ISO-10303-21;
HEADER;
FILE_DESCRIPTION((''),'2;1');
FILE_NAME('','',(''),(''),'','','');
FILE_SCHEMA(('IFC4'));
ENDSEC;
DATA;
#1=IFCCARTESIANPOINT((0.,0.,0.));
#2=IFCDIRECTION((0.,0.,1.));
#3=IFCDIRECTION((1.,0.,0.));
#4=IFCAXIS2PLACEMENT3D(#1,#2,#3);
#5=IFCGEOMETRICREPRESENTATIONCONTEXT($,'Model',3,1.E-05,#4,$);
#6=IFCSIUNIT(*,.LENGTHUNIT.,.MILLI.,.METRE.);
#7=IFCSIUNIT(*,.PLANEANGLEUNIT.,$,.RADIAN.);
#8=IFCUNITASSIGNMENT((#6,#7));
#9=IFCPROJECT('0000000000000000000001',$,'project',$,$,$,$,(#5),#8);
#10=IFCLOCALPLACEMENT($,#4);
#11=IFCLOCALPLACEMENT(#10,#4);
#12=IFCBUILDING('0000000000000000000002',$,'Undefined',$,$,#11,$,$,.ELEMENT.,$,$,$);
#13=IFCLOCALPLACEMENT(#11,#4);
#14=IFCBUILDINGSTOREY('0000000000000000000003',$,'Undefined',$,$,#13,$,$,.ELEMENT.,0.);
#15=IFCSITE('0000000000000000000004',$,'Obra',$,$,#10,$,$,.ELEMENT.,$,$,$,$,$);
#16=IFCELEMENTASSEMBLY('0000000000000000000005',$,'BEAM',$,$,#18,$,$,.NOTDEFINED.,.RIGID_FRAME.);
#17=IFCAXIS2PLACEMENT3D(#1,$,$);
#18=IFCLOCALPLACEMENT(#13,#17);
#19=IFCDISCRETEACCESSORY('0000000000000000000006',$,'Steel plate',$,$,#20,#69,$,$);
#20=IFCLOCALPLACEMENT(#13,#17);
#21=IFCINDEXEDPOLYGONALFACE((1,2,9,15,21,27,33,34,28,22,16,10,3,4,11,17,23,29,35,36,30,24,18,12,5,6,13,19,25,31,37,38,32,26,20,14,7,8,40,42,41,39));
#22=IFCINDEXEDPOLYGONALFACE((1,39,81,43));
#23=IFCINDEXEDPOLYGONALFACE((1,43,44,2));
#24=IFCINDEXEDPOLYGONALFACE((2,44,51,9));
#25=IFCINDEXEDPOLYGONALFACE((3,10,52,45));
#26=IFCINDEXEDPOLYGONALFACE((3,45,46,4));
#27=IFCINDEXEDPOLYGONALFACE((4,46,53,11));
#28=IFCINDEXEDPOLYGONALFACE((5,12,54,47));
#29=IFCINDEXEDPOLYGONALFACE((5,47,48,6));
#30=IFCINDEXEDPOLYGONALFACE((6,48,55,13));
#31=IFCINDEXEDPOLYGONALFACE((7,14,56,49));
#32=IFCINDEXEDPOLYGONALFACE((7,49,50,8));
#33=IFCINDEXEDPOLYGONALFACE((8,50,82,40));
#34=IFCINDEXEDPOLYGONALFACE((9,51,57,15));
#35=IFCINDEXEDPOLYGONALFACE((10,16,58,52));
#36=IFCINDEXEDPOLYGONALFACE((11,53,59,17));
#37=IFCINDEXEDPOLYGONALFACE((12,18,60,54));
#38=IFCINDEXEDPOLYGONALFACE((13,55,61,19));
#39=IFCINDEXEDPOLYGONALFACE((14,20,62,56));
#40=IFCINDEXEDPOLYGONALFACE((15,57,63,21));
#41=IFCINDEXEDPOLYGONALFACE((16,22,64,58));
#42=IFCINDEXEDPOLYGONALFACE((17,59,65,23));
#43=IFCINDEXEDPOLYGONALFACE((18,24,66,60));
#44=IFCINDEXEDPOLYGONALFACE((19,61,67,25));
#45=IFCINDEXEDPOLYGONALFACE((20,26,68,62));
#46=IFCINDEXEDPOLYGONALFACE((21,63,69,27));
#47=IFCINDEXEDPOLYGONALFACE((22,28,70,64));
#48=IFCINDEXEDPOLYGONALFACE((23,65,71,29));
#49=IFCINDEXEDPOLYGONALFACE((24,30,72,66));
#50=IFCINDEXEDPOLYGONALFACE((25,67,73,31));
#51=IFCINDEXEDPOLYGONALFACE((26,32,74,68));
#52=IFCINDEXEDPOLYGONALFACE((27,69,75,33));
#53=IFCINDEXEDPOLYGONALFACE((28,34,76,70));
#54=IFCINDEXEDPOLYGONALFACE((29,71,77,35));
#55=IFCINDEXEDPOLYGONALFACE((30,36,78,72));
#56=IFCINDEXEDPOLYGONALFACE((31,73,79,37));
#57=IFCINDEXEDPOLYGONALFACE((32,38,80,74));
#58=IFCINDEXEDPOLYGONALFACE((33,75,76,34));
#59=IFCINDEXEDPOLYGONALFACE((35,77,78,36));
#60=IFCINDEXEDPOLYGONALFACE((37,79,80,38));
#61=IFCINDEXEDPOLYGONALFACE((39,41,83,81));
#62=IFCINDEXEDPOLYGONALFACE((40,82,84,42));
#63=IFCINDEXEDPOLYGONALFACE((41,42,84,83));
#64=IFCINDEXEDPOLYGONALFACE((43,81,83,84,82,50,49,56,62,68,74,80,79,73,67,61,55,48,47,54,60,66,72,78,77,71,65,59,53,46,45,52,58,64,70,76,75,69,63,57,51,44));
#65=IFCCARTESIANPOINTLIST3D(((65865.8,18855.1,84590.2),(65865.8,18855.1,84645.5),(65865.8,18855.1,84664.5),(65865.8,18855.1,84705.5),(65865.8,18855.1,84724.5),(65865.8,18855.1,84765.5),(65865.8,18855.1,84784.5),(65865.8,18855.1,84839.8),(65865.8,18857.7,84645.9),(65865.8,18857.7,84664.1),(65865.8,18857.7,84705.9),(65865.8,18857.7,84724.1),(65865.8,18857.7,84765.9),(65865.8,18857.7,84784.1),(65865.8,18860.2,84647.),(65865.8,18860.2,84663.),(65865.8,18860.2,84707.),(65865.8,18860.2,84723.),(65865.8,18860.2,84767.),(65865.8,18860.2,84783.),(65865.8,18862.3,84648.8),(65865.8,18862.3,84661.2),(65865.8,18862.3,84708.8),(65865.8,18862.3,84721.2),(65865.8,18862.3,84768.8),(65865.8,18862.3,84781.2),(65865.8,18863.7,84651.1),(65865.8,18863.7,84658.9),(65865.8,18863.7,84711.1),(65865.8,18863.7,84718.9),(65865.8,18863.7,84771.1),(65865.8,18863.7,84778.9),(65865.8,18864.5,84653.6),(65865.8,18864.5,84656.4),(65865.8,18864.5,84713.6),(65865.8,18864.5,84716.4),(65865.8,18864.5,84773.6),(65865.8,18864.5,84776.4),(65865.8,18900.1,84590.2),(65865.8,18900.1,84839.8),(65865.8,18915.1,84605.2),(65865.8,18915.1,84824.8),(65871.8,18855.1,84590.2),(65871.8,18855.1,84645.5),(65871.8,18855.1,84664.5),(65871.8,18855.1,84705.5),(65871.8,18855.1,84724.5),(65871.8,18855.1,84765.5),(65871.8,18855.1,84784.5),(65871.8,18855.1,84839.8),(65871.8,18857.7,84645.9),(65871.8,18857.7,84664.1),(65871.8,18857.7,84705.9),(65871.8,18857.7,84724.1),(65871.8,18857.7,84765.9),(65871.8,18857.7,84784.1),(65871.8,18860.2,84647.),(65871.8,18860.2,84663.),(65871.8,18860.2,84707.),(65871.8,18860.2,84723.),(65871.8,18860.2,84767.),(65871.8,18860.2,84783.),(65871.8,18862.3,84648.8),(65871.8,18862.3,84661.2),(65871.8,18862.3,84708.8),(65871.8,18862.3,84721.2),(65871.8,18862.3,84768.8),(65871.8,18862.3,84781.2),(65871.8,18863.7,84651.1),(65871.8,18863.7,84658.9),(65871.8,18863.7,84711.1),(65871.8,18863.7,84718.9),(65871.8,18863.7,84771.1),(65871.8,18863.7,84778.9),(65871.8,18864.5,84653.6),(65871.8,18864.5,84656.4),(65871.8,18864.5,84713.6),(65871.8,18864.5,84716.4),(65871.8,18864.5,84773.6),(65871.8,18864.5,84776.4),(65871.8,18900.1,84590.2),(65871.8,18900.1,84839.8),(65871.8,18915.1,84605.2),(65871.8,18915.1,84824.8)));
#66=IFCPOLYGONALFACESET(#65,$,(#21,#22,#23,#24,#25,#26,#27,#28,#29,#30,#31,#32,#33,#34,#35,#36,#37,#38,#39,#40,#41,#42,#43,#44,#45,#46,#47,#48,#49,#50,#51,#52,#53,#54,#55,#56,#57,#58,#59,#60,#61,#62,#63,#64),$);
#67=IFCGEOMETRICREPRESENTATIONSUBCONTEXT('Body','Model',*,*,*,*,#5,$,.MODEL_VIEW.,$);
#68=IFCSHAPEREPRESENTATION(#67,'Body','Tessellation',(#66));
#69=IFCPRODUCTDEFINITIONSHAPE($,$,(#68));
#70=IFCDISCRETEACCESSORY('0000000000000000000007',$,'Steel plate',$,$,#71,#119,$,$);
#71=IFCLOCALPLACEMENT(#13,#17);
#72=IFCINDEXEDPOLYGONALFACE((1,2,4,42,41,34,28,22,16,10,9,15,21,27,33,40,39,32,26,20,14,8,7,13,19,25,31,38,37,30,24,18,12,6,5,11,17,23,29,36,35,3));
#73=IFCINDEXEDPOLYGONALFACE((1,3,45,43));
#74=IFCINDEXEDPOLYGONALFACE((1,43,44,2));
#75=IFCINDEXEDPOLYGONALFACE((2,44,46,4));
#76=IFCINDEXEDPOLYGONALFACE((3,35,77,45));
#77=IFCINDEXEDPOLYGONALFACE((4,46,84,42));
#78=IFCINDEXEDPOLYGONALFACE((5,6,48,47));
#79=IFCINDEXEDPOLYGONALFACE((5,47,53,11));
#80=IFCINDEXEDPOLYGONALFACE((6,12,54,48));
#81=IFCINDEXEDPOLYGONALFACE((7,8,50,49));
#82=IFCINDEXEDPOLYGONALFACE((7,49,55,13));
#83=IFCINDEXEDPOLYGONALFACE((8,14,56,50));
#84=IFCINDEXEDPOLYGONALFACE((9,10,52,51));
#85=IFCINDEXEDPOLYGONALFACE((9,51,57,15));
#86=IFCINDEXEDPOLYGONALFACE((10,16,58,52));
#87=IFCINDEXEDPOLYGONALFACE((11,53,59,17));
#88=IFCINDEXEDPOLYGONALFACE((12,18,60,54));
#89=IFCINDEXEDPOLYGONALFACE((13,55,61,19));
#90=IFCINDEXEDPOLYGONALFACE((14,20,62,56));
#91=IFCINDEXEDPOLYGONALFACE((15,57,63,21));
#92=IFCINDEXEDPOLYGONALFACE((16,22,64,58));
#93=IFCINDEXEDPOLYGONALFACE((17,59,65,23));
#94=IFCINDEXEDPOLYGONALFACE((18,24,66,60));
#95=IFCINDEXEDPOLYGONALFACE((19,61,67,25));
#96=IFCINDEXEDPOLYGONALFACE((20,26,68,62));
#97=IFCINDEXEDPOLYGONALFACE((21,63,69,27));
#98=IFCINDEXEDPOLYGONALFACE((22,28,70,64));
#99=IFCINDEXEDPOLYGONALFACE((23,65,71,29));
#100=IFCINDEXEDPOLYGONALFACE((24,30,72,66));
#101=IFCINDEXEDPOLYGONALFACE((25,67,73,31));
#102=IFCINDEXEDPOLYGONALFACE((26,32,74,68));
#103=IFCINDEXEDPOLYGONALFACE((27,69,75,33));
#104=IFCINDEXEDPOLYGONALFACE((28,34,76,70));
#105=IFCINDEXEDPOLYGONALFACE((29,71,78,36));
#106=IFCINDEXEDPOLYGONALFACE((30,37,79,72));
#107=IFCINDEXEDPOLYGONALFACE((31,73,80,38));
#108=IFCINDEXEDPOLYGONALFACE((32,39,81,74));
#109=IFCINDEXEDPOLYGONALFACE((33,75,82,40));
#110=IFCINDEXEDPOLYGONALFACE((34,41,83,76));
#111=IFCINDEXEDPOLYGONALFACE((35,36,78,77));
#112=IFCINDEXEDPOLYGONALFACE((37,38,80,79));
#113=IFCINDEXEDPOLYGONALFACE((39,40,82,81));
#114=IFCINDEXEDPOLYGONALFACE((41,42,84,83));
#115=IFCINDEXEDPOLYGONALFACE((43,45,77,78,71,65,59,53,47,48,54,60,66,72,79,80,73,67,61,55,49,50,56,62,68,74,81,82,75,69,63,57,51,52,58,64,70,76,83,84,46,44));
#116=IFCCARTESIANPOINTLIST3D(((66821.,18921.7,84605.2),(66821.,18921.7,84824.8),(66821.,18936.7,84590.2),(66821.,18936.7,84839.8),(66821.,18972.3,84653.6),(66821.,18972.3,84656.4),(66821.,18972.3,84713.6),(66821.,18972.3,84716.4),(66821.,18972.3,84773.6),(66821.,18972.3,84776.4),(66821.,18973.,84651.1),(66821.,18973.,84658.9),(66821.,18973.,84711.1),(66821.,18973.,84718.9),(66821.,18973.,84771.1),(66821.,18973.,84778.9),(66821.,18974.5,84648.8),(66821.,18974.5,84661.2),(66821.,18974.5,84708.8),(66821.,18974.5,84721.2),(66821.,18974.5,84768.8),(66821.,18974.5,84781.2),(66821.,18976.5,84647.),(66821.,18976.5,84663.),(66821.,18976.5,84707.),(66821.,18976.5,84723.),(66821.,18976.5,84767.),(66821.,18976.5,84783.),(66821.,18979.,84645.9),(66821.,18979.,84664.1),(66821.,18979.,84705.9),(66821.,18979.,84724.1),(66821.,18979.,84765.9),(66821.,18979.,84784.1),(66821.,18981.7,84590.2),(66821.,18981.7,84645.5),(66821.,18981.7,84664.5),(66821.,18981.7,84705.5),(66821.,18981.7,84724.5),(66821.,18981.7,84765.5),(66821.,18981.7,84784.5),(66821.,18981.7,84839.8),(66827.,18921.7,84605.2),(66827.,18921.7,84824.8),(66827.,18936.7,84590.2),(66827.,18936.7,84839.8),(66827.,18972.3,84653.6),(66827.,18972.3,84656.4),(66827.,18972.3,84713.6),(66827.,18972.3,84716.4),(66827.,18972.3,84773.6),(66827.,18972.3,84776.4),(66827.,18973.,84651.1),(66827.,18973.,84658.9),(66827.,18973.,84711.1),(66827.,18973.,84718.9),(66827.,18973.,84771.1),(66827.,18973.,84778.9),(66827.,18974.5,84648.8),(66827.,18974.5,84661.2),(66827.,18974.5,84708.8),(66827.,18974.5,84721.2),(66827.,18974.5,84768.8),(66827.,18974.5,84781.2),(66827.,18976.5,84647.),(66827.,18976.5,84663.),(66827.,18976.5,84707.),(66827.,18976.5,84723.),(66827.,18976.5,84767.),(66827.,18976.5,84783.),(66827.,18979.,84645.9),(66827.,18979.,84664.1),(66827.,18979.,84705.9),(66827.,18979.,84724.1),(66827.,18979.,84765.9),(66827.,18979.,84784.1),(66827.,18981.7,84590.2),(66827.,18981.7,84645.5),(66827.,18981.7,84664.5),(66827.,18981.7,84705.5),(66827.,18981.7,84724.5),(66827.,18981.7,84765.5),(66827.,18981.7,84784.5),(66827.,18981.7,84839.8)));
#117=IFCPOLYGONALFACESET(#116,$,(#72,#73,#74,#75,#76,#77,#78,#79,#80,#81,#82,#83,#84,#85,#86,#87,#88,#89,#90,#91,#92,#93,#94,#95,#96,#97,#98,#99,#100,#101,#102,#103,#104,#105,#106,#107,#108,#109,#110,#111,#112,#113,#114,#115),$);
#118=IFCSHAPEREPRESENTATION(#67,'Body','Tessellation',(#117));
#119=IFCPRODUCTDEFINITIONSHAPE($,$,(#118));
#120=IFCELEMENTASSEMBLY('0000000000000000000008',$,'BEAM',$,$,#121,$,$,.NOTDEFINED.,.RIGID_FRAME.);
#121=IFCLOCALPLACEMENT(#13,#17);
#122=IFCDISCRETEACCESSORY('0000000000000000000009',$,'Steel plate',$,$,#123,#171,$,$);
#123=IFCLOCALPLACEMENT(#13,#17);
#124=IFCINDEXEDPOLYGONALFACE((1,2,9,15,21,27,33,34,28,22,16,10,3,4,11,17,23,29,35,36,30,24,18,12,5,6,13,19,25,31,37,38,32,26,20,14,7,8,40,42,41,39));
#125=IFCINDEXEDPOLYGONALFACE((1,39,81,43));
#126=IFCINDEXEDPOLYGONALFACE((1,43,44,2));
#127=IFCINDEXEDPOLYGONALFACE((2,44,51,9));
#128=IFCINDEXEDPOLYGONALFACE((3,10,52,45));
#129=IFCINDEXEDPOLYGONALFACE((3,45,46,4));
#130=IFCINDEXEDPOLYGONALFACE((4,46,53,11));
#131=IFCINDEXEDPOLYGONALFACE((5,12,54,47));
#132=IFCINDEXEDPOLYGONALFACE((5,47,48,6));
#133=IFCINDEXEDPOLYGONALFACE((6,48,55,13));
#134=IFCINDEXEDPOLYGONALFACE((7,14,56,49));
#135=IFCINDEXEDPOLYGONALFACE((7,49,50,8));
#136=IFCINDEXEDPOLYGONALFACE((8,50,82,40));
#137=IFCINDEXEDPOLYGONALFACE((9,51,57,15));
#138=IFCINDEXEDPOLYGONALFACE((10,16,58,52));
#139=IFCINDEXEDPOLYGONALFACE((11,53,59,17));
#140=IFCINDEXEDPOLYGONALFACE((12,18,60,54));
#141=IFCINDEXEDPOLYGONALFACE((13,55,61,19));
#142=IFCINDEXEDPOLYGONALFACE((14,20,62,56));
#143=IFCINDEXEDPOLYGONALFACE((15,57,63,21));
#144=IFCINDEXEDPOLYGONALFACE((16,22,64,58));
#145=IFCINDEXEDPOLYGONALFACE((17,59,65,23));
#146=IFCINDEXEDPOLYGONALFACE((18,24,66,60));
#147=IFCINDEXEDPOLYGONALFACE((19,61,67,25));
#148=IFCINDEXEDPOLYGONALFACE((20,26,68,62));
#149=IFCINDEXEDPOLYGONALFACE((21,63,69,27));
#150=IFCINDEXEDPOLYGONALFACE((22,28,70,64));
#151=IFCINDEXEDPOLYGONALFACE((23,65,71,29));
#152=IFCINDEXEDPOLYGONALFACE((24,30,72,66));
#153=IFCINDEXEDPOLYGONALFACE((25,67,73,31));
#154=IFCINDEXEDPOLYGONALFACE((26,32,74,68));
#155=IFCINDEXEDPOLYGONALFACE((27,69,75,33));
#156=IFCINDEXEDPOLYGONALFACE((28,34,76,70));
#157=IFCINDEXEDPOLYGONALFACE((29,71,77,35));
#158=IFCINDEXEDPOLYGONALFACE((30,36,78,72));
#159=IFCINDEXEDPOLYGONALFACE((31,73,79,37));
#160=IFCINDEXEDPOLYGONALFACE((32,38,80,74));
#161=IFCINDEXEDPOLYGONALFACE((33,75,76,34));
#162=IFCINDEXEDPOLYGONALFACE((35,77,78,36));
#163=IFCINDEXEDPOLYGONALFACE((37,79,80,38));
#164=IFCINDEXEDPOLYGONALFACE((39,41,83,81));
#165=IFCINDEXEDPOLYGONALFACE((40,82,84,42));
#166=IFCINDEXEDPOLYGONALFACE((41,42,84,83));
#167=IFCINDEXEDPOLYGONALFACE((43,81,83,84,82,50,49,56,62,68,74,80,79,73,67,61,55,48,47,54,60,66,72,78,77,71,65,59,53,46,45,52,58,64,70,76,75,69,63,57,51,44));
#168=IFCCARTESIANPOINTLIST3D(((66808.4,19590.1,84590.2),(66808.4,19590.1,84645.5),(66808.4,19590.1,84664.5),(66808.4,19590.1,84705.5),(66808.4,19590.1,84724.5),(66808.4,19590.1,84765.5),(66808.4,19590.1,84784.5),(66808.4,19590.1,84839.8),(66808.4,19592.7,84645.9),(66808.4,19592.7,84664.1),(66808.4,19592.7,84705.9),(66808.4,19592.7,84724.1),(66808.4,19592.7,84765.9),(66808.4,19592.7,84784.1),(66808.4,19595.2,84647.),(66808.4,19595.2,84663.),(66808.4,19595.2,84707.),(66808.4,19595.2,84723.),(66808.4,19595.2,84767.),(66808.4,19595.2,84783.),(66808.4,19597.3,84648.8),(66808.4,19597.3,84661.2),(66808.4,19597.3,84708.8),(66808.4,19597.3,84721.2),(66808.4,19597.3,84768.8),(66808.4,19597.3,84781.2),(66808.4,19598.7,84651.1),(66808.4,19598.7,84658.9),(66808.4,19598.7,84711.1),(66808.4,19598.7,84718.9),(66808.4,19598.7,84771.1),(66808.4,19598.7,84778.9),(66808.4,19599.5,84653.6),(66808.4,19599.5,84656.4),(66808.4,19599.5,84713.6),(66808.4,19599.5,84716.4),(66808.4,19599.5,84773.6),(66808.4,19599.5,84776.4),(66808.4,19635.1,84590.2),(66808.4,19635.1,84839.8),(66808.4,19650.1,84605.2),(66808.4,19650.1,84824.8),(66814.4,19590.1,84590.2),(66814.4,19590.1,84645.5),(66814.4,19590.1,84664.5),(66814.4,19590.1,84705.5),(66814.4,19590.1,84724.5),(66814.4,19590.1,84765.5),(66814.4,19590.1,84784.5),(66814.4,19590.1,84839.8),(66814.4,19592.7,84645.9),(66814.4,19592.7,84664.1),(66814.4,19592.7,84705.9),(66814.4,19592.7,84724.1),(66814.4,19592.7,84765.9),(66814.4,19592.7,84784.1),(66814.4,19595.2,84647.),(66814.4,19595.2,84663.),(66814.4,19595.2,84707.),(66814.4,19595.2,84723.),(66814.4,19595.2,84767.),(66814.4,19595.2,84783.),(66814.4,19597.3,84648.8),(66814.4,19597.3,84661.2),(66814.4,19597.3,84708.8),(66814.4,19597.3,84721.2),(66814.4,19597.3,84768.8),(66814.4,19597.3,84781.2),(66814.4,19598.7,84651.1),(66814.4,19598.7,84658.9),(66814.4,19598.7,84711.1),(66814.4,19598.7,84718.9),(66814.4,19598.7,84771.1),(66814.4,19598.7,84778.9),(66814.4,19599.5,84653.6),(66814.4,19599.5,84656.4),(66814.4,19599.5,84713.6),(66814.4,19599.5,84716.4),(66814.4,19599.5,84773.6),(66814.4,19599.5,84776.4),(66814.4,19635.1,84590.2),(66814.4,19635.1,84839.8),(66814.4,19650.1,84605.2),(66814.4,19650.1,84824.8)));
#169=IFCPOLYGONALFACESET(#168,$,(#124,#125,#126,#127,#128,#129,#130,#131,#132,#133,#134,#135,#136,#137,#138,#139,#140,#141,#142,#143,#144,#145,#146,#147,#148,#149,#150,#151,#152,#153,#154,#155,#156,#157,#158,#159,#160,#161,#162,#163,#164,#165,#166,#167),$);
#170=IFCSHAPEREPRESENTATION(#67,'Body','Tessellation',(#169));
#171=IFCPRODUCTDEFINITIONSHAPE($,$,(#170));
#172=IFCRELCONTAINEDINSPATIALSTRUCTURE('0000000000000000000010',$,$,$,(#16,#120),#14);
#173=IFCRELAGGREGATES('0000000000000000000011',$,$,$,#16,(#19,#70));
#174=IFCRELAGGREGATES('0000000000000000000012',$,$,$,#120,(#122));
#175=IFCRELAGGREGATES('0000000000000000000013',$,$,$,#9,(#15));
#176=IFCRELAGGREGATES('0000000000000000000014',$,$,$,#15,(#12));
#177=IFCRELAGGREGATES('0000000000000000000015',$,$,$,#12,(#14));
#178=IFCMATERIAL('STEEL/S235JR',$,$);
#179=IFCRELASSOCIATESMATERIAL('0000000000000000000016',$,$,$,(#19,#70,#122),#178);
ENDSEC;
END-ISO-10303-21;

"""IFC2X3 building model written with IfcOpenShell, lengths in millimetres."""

from ifc_helpers import new_model, si_unit, frame, origin_with_axes, origin_2d_with_axis, place, context, subcontext, project, spatial, polyline, circle, outline, extrude, source, transform, mapped, material, element, aggregate, save


model = new_model("IFC2X3")

# Units and contexts
model_context = context("Model", 3, precision=1e-05, world=origin_with_axes())
body_context = subcontext(model_context, "Body", "Model", "MODEL_VIEW")
ifc_project = project(units=[si_unit("LENGTHUNIT", "METRE", prefix="MILLI"), si_unit("PLANEANGLEUNIT", "RADIAN")], contexts=[model_context])

# Site, building, storey
site_placement = place(None, origin_with_axes())
site = spatial("IfcSite", under=ifc_project, at=site_placement, Name="Obra", CompositionType="ELEMENT")
building_placement = place(site_placement, origin_with_axes())
building = spatial("IfcBuilding", under=site, at=building_placement, Name="Undefined", CompositionType="ELEMENT")
storey_placement = place(building_placement, origin_with_axes())
storey = spatial("IfcBuildingStorey", under=building, at=storey_placement, Name="Undefined", CompositionType="ELEMENT", Elevation=0.0)

# Shared definitions
ifc_material = material(Name="STEEL/S235JR")

# Element assemblies, discrete accessories, openings
assembly_1_placement = place(storey_placement, origin_with_axes())
assembly_1 = element("IfcElementAssembly", 1, at=assembly_1_placement, inside=storey, Name="BEAM", AssemblyPlace="NOTDEFINED", PredefinedType="RIGID_FRAME")
discrete_accessory_1_placement = place(assembly_1_placement, frame((65868.8, 18855.1, 84590.2), z_axis=(1.0, 0.000001, 0.0), x_axis=(-0.000002, 1.0, 0.0)))
discrete_accessory_1 = element("IfcDiscreteAccessory", 2, at=discrete_accessory_1_placement, material=ifc_material, Name="Steel plate", context=body_context, shape_type="SweptSolid", body=[
    extrude(outline(polyline([(0.0, 0.0), (45.0, 0.0), (60.0, 15.0), (60.0, 234.6), (45.0, 249.6), (0.0, 249.6), (0.0, 0.0)])), frame((0.0, 0.0, -3.0), z_axis=(0.0, 0.0, 1.0), x_axis=(1.0, 0.0, 0.0)), (0.0, 0.0, 1.0), 6.0),
])
shared_shape_1 = source(origin_with_axes(), body_context, "Body", "SweptSolid", [
    extrude(circle(Radius=9.5, at=origin_2d_with_axis()), frame((0.0, -9.4, 0.0), z_axis=(0.0, 1.0, 0.0), x_axis=(1.0, 0.0, 0.0)), (0.0, 0.0, 1.0), 6.2),
])
opening_1_placement = place(assembly_1_placement, frame((65875.1, 18905.1, 84850.0), z_axis=(0.000002, -1.0, 0.0), x_axis=(0.0, 0.0, -1.0)))
element("IfcOpeningElement", 3, at=opening_1_placement, cuts=discrete_accessory_1, ObjectType="Opening", context=body_context, shape_type="MappedRepresentation", body=[
    mapped(shared_shape_1, transform((75.0, 0.0, 50.0))),
    mapped(shared_shape_1, transform((135.0, 0.0, 50.0))),
    mapped(shared_shape_1, transform((195.0, 0.0, 50.0))),
])
discrete_accessory_2_placement = place(assembly_1_placement, frame((66824.0, 18981.7, 84590.2), z_axis=(-1.0, -0.000002, 0.0), x_axis=(0.000002, -1.0, 0.0)))
discrete_accessory_2 = element("IfcDiscreteAccessory", 4, at=discrete_accessory_2_placement, material=ifc_material, Name="Steel plate", context=body_context, shape_type="SweptSolid", body=[
    extrude(outline(polyline([(0.0, 0.0), (45.0, 0.0), (60.0, 15.0), (60.0, 234.6), (45.0, 249.6), (0.0, 249.6), (0.0, 0.0)])), frame((0.0, 0.0, -3.0), z_axis=(0.0, 0.0, 1.0), x_axis=(1.0, 0.0, 0.0)), (0.0, 0.0, 1.0), 6.0),
])
opening_2_placement = place(assembly_1_placement, frame((66817.7, 18931.7, 84850.0), z_axis=(-0.000002, 1.0, 0.0), x_axis=(0.0, 0.0, -1.0)))
element("IfcOpeningElement", 5, at=opening_2_placement, cuts=discrete_accessory_2, ObjectType="Opening", context=body_context, shape_type="MappedRepresentation", body=[
    mapped(shared_shape_1, transform((75.0, 0.0, 50.0))),
    mapped(shared_shape_1, transform((135.0, 0.0, 50.0))),
    mapped(shared_shape_1, transform((195.0, 0.0, 50.0))),
])
aggregate(assembly_1, [discrete_accessory_1, discrete_accessory_2])
assembly_2_placement = place(storey_placement, origin_with_axes())
assembly_2 = element("IfcElementAssembly", 6, at=assembly_2_placement, inside=storey, Name="BEAM", AssemblyPlace="NOTDEFINED", PredefinedType="RIGID_FRAME")
discrete_accessory_3_placement = place(assembly_2_placement, frame((66811.4, 19590.1, 84590.2), z_axis=(1.0, 0.000001, 0.0), x_axis=(-0.000002, 1.0, 0.0)))
discrete_accessory_3 = element("IfcDiscreteAccessory", 7, at=discrete_accessory_3_placement, material=ifc_material, Name="Steel plate", context=body_context, shape_type="SweptSolid", body=[
    extrude(outline(polyline([(0.0, 0.0), (45.0, 0.0), (60.0, 15.0), (60.0, 234.6), (45.0, 249.6), (0.0, 249.6), (0.0, 0.0)])), frame((0.0, 0.0, -3.0), z_axis=(0.0, 0.0, 1.0), x_axis=(1.0, 0.0, 0.0)), (0.0, 0.0, 1.0), 6.0),
])
opening_3_placement = place(assembly_2_placement, frame((66817.7, 19640.1, 84850.0), z_axis=(0.000002, -1.0, 0.0), x_axis=(0.0, 0.0, -1.0)))
element("IfcOpeningElement", 8, at=opening_3_placement, cuts=discrete_accessory_3, ObjectType="Opening", context=body_context, shape_type="MappedRepresentation", body=[
    mapped(shared_shape_1, transform((75.0, 0.0, 50.0))),
    mapped(shared_shape_1, transform((135.0, 0.0, 50.0))),
    mapped(shared_shape_1, transform((195.0, 0.0, 50.0))),
])
aggregate(assembly_2, [discrete_accessory_3])

save(model, "model.ifc")
